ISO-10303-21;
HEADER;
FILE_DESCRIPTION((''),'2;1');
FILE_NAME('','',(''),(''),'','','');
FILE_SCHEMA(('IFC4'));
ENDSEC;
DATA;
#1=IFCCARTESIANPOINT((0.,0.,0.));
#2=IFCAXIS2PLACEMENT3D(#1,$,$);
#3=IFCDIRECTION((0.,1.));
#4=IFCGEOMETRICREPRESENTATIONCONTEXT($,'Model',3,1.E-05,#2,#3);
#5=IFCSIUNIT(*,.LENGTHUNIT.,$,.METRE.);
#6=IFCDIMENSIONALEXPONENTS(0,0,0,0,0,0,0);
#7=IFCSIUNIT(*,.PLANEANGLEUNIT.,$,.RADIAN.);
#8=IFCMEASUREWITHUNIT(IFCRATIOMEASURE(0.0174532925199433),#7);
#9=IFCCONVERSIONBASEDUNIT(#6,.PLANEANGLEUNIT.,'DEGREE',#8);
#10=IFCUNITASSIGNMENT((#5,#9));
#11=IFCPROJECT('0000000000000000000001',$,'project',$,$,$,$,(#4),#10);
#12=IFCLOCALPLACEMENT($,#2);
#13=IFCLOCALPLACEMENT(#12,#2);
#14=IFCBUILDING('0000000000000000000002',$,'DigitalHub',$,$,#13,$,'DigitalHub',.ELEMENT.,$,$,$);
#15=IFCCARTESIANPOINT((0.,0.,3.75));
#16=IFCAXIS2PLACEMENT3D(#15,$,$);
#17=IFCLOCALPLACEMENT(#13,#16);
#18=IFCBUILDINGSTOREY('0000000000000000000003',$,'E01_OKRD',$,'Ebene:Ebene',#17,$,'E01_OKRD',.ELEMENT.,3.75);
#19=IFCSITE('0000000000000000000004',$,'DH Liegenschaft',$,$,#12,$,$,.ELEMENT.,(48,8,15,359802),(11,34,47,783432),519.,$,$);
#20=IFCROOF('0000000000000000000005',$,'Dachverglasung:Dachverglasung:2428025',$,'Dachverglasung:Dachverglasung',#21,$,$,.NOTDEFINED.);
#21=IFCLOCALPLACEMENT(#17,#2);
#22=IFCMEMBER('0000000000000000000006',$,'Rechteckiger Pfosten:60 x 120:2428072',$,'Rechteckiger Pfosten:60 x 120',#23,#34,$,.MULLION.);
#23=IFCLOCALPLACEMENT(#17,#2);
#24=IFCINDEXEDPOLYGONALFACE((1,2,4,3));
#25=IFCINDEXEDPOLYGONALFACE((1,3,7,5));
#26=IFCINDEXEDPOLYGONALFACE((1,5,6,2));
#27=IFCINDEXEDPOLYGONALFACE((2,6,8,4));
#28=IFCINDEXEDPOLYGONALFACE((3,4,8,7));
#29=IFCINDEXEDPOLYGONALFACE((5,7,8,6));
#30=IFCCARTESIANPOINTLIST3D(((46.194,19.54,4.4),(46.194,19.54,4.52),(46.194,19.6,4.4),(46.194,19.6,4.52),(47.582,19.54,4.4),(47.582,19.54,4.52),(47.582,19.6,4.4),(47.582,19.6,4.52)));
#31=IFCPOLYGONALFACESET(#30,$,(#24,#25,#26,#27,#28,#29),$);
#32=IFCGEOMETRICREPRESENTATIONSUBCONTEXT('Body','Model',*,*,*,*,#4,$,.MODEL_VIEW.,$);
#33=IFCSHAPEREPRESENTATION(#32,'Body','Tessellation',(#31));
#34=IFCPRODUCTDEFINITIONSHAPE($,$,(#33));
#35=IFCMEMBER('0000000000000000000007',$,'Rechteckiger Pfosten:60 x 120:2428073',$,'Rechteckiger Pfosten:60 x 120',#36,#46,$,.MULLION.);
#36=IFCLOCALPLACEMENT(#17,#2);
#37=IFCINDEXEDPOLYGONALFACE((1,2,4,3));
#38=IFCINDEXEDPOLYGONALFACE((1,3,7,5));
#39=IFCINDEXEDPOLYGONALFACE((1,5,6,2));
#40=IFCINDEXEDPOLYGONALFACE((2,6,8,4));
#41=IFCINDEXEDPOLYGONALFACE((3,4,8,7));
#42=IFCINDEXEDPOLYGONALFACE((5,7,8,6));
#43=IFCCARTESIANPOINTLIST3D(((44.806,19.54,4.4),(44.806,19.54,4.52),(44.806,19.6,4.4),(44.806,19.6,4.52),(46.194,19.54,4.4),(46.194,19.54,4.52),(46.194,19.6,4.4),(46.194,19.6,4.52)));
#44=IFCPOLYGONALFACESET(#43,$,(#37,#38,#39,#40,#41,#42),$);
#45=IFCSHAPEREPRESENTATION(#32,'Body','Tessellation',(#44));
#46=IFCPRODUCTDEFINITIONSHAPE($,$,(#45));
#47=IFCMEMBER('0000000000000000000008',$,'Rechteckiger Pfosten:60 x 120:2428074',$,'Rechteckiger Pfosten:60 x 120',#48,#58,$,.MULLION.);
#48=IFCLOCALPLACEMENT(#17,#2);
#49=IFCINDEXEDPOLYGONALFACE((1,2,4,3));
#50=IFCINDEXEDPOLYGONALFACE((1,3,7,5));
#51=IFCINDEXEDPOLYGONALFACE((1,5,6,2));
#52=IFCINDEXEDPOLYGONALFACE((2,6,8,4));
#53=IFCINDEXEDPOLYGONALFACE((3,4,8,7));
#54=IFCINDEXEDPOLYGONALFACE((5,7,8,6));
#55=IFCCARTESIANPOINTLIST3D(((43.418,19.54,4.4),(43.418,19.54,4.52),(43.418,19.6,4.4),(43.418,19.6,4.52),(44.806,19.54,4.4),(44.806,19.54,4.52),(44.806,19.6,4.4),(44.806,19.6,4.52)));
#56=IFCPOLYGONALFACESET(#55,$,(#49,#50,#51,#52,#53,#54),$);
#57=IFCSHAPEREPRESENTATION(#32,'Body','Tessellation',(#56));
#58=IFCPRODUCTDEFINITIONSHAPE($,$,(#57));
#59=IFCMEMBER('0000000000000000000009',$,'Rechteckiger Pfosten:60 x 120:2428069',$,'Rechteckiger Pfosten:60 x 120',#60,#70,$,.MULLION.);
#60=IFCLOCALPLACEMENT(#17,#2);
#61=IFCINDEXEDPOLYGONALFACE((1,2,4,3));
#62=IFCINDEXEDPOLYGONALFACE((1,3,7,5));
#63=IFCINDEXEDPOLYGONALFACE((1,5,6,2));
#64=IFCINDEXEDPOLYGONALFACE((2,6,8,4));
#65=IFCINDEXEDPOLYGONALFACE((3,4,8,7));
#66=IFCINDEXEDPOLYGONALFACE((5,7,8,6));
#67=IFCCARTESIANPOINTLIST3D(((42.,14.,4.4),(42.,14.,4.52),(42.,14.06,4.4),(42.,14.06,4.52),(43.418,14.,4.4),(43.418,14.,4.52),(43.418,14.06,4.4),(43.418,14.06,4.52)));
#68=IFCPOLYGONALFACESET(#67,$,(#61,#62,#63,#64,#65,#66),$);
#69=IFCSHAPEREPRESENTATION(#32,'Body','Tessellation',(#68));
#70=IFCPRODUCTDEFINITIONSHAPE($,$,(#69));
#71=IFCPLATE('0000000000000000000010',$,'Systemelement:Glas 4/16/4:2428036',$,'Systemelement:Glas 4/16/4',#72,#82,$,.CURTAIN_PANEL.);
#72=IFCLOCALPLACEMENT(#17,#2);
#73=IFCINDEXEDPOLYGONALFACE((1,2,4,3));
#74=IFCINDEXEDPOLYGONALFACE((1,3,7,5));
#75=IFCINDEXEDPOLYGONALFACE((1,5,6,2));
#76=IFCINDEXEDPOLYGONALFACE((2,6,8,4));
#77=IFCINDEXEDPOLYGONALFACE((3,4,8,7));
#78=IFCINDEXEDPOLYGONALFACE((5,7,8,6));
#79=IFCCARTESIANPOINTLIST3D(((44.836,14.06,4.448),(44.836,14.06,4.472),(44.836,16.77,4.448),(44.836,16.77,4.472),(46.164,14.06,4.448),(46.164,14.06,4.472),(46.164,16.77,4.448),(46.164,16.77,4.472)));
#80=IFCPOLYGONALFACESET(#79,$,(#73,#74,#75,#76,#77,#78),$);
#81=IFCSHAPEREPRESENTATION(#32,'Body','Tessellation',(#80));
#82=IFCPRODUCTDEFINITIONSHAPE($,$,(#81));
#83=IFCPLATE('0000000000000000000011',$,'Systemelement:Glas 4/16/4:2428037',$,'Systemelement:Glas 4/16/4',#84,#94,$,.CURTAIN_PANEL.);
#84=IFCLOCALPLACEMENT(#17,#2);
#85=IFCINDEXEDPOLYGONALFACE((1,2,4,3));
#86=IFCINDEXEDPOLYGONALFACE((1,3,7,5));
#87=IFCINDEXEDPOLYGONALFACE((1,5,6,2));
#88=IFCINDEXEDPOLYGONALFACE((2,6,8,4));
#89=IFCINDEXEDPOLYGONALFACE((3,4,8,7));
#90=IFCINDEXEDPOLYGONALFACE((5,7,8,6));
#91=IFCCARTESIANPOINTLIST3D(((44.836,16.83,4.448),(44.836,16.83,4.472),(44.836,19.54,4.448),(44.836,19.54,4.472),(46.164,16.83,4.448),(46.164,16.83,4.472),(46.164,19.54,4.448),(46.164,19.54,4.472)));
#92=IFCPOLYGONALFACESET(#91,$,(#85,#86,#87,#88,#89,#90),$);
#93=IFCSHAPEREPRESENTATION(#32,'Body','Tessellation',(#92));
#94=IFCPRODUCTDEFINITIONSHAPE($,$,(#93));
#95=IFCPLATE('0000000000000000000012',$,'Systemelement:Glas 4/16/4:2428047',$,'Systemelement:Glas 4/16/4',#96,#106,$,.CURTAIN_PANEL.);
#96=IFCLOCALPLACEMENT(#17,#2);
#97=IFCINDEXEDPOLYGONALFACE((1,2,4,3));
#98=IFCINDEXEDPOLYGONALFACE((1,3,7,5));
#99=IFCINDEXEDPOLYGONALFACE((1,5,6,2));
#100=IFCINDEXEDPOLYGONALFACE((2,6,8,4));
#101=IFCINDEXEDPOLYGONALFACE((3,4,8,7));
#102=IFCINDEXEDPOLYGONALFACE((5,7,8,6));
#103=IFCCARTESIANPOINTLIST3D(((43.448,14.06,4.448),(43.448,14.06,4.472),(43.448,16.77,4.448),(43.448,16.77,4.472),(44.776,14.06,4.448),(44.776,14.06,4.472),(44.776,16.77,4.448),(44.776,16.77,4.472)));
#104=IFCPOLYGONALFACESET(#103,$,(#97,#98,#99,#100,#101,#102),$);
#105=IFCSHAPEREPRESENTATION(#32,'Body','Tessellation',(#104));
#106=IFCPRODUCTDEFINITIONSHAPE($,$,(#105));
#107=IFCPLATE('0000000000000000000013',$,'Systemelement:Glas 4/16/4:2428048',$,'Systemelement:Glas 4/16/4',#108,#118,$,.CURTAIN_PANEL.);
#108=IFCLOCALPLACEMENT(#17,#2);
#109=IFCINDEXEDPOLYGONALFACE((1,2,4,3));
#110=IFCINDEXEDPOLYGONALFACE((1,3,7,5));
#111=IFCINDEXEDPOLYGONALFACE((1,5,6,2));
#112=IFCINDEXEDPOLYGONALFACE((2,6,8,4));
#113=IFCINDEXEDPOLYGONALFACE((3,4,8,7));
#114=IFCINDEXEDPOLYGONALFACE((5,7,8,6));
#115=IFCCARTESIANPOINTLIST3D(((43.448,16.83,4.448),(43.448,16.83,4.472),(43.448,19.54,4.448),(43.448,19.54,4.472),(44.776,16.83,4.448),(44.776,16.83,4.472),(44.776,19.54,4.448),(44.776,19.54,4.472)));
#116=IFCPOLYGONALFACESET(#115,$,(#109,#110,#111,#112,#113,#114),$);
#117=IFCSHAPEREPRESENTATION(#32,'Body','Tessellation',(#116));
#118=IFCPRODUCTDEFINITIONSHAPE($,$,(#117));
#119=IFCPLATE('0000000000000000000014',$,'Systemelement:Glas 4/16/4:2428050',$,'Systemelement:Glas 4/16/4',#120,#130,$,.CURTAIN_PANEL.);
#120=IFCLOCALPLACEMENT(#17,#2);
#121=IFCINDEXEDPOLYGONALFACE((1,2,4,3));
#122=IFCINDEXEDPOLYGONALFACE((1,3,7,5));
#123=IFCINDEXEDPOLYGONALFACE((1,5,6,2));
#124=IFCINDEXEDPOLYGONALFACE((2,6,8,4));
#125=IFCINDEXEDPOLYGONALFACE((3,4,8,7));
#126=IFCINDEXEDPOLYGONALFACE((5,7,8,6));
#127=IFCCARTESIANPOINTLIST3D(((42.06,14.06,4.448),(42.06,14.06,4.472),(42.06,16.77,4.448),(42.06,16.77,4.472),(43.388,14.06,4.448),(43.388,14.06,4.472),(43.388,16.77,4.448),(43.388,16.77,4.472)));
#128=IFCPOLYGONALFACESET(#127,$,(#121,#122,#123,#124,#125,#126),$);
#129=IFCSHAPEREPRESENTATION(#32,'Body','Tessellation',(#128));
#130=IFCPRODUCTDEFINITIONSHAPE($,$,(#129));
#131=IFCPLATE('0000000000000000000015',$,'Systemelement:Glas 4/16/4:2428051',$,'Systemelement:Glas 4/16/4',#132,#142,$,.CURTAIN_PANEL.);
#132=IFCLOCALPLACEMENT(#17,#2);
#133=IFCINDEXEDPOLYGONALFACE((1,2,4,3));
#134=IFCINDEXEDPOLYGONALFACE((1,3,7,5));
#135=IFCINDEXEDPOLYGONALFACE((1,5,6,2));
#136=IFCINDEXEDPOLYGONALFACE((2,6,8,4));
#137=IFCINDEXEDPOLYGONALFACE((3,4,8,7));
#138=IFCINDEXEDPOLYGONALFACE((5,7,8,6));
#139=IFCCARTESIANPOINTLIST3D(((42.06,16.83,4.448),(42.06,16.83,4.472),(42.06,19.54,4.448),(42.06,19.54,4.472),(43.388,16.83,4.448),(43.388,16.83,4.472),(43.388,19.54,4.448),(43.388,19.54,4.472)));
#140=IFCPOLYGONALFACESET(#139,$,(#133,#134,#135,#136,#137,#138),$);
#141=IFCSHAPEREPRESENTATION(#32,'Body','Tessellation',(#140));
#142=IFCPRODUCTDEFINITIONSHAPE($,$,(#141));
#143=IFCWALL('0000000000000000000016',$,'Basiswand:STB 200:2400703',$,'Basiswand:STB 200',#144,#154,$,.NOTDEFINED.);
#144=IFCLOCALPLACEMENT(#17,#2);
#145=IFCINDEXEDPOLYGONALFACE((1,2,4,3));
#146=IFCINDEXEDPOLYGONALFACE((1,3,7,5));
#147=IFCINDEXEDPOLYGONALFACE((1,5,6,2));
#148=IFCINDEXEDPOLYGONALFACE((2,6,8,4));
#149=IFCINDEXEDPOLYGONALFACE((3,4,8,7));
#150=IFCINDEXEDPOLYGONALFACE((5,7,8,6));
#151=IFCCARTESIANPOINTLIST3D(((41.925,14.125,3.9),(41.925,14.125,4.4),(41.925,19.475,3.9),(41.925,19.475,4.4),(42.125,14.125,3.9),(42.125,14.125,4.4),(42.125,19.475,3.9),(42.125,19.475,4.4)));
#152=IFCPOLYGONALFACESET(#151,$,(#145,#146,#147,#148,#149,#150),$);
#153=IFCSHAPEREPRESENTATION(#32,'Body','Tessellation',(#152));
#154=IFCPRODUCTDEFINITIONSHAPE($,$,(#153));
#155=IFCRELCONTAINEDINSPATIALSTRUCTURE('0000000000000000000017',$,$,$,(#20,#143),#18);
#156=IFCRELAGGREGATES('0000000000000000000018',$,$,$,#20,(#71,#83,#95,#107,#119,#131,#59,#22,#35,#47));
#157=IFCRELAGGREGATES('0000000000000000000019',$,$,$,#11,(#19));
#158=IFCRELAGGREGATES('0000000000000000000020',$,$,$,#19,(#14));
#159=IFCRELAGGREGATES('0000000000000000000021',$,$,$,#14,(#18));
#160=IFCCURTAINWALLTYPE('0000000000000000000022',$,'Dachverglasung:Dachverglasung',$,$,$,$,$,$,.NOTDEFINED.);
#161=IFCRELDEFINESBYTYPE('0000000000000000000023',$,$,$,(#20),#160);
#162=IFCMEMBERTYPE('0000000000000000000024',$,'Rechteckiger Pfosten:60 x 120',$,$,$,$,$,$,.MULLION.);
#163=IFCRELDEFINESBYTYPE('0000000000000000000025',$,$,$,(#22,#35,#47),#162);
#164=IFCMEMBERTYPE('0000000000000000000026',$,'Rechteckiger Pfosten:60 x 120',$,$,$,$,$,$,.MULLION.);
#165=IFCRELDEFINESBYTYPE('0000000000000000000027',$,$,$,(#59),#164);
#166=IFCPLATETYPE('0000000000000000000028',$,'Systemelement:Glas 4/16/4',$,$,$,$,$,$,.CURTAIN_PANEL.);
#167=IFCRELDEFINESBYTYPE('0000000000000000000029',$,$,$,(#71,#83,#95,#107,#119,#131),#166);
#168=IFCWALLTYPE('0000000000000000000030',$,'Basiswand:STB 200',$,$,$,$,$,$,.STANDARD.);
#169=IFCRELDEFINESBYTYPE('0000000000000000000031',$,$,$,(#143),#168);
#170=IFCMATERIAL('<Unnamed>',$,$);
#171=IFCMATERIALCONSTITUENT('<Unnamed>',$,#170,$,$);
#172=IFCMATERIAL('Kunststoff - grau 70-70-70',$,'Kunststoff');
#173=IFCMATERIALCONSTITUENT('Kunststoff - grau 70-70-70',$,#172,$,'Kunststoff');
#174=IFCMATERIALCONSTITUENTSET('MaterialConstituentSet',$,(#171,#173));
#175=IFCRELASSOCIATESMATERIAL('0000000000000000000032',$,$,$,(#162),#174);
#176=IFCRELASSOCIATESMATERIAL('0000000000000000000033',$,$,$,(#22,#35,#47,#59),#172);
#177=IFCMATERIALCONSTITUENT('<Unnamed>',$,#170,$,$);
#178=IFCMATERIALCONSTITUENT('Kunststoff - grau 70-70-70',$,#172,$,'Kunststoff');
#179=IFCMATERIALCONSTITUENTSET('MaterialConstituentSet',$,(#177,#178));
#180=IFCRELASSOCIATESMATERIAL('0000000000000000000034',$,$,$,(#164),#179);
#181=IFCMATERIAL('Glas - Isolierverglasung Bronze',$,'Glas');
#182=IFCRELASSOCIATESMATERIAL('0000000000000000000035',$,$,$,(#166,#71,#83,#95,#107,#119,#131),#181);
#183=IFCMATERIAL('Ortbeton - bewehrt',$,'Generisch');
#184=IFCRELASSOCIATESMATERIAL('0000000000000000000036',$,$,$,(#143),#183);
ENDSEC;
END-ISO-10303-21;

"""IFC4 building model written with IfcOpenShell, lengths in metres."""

from ifc_helpers import new_model, entity, si_unit, converted_unit, direction, frame, origin, place, context, subcontext, project, spatial, indexed_curve, outline, extrude, source, transform, mapped, material, constituent, constituent_set, type_object, type_shapes, element, aggregate, save


model = new_model("IFC4")

# Units and contexts
model_context = context("Model", 3, precision=1e-05, world=origin(), true_north=direction((0.0, 1.0)))
body_context = subcontext(model_context, "Body", "Model", "MODEL_VIEW")
ifc_project = project(units=[si_unit("LENGTHUNIT", "METRE"), converted_unit("PLANEANGLEUNIT", "DEGREE", entity("IfcRatioMeasure", 0.0174532925199433), si_unit("PLANEANGLEUNIT", "RADIAN"), dimensions=[0, 0, 0, 0, 0, 0, 0])], contexts=[model_context])

# Site, building, storey
site_placement = place(None, frame((0.0, 0.0, 0.0)))
site = spatial("IfcSite", under=ifc_project, at=site_placement, Name="DH Liegenschaft", CompositionType="ELEMENT", RefLatitude=(48, 8, 15, 359802), RefLongitude=(11, 34, 47, 783432), RefElevation=519.0)
building_placement = place(site_placement, origin())
building = spatial("IfcBuilding", under=site, at=building_placement, Name="DigitalHub", LongName="DigitalHub", CompositionType="ELEMENT")
storey_placement = place(building_placement, frame((0.0, 0.0, 3.75)))
storey = spatial("IfcBuildingStorey", under=building, at=storey_placement, Name="E01_OKRD", ObjectType="Ebene:Ebene", LongName="E01_OKRD", CompositionType="ELEMENT", Elevation=3.75)

# Roof, members, plates
curtain_wall_type = type_object("IfcCurtainWallType", Name="Dachverglasung:Dachverglasung", PredefinedType="NOTDEFINED")
roof_placement = place(storey_placement, frame((0.0, 0.0, -3.75)))
roof = element("IfcRoof", 1, at=roof_placement, inside=storey, type_object=curtain_wall_type, Name="Dachverglasung:Dachverglasung:2428025", ObjectType="Dachverglasung:Dachverglasung", PredefinedType="NOTDEFINED")
ifc_material_1 = material(Name="Kunststoff - grau 70-70-70", Category="Kunststoff")
ifc_material_2 = material(Name="<Unnamed>")
ifc_constituent_1 = constituent(ifc_material_2, Name="<Unnamed>")
ifc_constituent_2 = constituent(ifc_material_1, Name="Kunststoff - grau 70-70-70", Category="Kunststoff")
ifc_constituent_set_1 = constituent_set(constituents=[ifc_constituent_1, ifc_constituent_2], Name="MaterialConstituentSet")
member_type_1 = type_object("IfcMemberType", Name="Rechteckiger Pfosten:60 x 120", PredefinedType="MULLION", material=ifc_constituent_set_1)
shared_shape_1 = source(origin(), body_context, "Body", "SweptSolid", [
    extrude(outline(indexed_curve([(-0.06, -0.03), (0.06, -0.03), (0.06, 0.03), (-0.06, 0.03), (-0.06, -0.03)], self_intersect=False)), frame((-0.03, 0.0, -1.388), z_axis=(0.0, 0.0, 1.0), x_axis=(0.0, -1.0, 0.0)), (0.0, 0.0, 1.0), 1.388),
])
type_shapes(member_type_1, [shared_shape_1])
member_1_placement = place(storey_placement, frame((46.194, 19.6, 4.46), z_axis=(-1.0, 0.0, 0.0), x_axis=(0.0, 1.0, 0.0)))
member_1 = element("IfcMember", 2, at=member_1_placement, type_object=member_type_1, material=ifc_material_1, Name="Rechteckiger Pfosten:60 x 120:2428072", ObjectType="Rechteckiger Pfosten:60 x 120", PredefinedType="MULLION", context=body_context, shape_type="MappedRepresentation", body=[
    mapped(shared_shape_1, transform((0.0, 0.0, 0.0), scale=1.0)),
])
member_2_placement = place(storey_placement, frame((44.806, 19.6, 4.46), z_axis=(-1.0, 0.0, 0.0), x_axis=(0.0, 1.0, 0.0)))
member_2 = element("IfcMember", 3, at=member_2_placement, type_object=member_type_1, material=ifc_material_1, Name="Rechteckiger Pfosten:60 x 120:2428073", ObjectType="Rechteckiger Pfosten:60 x 120", PredefinedType="MULLION", context=body_context, shape_type="MappedRepresentation", body=[
    mapped(shared_shape_1, transform((0.0, 0.0, 0.0), scale=1.0)),
])
member_3_placement = place(storey_placement, frame((43.418, 19.6, 4.46), z_axis=(-1.0, 0.0, 0.0), x_axis=(0.0, 1.0, 0.0)))
member_3 = element("IfcMember", 4, at=member_3_placement, type_object=member_type_1, material=ifc_material_1, Name="Rechteckiger Pfosten:60 x 120:2428074", ObjectType="Rechteckiger Pfosten:60 x 120", PredefinedType="MULLION", context=body_context, shape_type="MappedRepresentation", body=[
    mapped(shared_shape_1, transform((0.0, 0.0, 0.0), scale=1.0)),
])
ifc_constituent_3 = constituent(ifc_material_2, Name="<Unnamed>")
ifc_constituent_4 = constituent(ifc_material_1, Name="Kunststoff - grau 70-70-70", Category="Kunststoff")
ifc_constituent_set_2 = constituent_set(constituents=[ifc_constituent_3, ifc_constituent_4], Name="MaterialConstituentSet")
member_type_2 = type_object("IfcMemberType", Name="Rechteckiger Pfosten:60 x 120", PredefinedType="MULLION", material=ifc_constituent_set_2)
shared_shape_2 = source(origin(), body_context, "Body", "SweptSolid", [
    extrude(outline(indexed_curve([(-0.06, -0.03), (0.06, -0.03), (0.06, 0.03), (-0.06, 0.03), (-0.06, -0.03)], self_intersect=False)), frame((-0.03, 0.0, -1.418), z_axis=(0.0, 0.0, 1.0), x_axis=(0.0, -1.0, 0.0)), (0.0, 0.0, 1.0), 1.418),
])
type_shapes(member_type_2, [shared_shape_2])
member_4_placement = place(storey_placement, frame((43.418, 14.0, 4.46), z_axis=(1.0, 0.0, 0.0), x_axis=(0.0, -1.0, 0.0)))
member_4 = element("IfcMember", 5, at=member_4_placement, type_object=member_type_2, material=ifc_material_1, Name="Rechteckiger Pfosten:60 x 120:2428069", ObjectType="Rechteckiger Pfosten:60 x 120", PredefinedType="MULLION", context=body_context, shape_type="MappedRepresentation", body=[
    mapped(shared_shape_2, transform((0.0, 0.0, 0.0), scale=1.0)),
])
ifc_material_3 = material(Name="Glas - Isolierverglasung Bronze", Category="Glas")
plate_type = type_object("IfcPlateType", Name="Systemelement:Glas 4/16/4", PredefinedType="CURTAIN_PANEL", material=ifc_material_3)
shared_shape_3 = source(origin(), body_context, "Body", "SweptSolid", [
    extrude(outline(indexed_curve([(-0.012, -1.355), (0.012, -1.355), (0.012, 1.355), (-0.012, 1.355), (-0.012, -1.355)], self_intersect=False)), frame((0.0, 0.0, 0.0), z_axis=(0.0, 0.0, 1.0), x_axis=(0.0, 1.0, 0.0)), (0.0, 0.0, 1.0), 1.328),
])
type_shapes(plate_type, [shared_shape_3])
plate_1_placement = place(roof_placement, frame((46.164, 15.415, 8.21), z_axis=(-1.0, 0.0, 0.0), x_axis=(0.0, 1.0, 0.0)))
plate_1 = element("IfcPlate", 6, at=plate_1_placement, type_object=plate_type, material=ifc_material_3, Name="Systemelement:Glas 4/16/4:2428036", ObjectType="Systemelement:Glas 4/16/4", PredefinedType="CURTAIN_PANEL", context=body_context, shape_type="MappedRepresentation", body=[
    mapped(shared_shape_3, transform((0.0, 0.0, 0.0), scale=1.0)),
])
plate_2_placement = place(roof_placement, frame((46.164, 18.185, 8.21), z_axis=(-1.0, 0.0, 0.0), x_axis=(0.0, 1.0, 0.0)))
plate_2 = element("IfcPlate", 7, at=plate_2_placement, type_object=plate_type, material=ifc_material_3, Name="Systemelement:Glas 4/16/4:2428037", ObjectType="Systemelement:Glas 4/16/4", PredefinedType="CURTAIN_PANEL", context=body_context, shape_type="MappedRepresentation", body=[
    mapped(shared_shape_3, transform((0.0, 0.0, 0.0), scale=1.0)),
])
plate_3_placement = place(roof_placement, frame((44.776, 15.415, 8.21), z_axis=(-1.0, 0.0, 0.0), x_axis=(0.0, 1.0, 0.0)))
plate_3 = element("IfcPlate", 8, at=plate_3_placement, type_object=plate_type, material=ifc_material_3, Name="Systemelement:Glas 4/16/4:2428047", ObjectType="Systemelement:Glas 4/16/4", PredefinedType="CURTAIN_PANEL", context=body_context, shape_type="MappedRepresentation", body=[
    mapped(shared_shape_3, transform((0.0, 0.0, 0.0), scale=1.0)),
])
plate_4_placement = place(roof_placement, frame((44.776, 18.185, 8.21), z_axis=(-1.0, 0.0, 0.0), x_axis=(0.0, 1.0, 0.0)))
plate_4 = element("IfcPlate", 9, at=plate_4_placement, type_object=plate_type, material=ifc_material_3, Name="Systemelement:Glas 4/16/4:2428048", ObjectType="Systemelement:Glas 4/16/4", PredefinedType="CURTAIN_PANEL", context=body_context, shape_type="MappedRepresentation", body=[
    mapped(shared_shape_3, transform((0.0, 0.0, 0.0), scale=1.0)),
])
plate_5_placement = place(roof_placement, frame((43.388, 15.415, 8.21), z_axis=(-1.0, 0.0, 0.0), x_axis=(0.0, 1.0, 0.0)))
plate_5 = element("IfcPlate", 10, at=plate_5_placement, type_object=plate_type, material=ifc_material_3, Name="Systemelement:Glas 4/16/4:2428050", ObjectType="Systemelement:Glas 4/16/4", PredefinedType="CURTAIN_PANEL", context=body_context, shape_type="MappedRepresentation", body=[
    mapped(shared_shape_3, transform((0.0, 0.0, 0.0), scale=1.0)),
])
plate_6_placement = place(roof_placement, frame((43.388, 18.185, 8.21), z_axis=(-1.0, 0.0, 0.0), x_axis=(0.0, 1.0, 0.0)))
plate_6 = element("IfcPlate", 11, at=plate_6_placement, type_object=plate_type, material=ifc_material_3, Name="Systemelement:Glas 4/16/4:2428051", ObjectType="Systemelement:Glas 4/16/4", PredefinedType="CURTAIN_PANEL", context=body_context, shape_type="MappedRepresentation", body=[
    mapped(shared_shape_3, transform((0.0, 0.0, 0.0), scale=1.0)),
])
aggregate(roof, [plate_1, plate_2, plate_3, plate_4, plate_5, plate_6, member_4, member_1, member_2, member_3])

# Wall
ifc_material_4 = material(Name="Ortbeton - bewehrt", Category="Generisch")
wall_type_1 = type_object("IfcWallType", Name="Basiswand:STB 200", PredefinedType="STANDARD")
wall_1_placement = place(storey_placement, frame((42.025, 14.125, 3.9), z_axis=(0.0, 0.0, 1.0), x_axis=(0.0, 1.0, 0.0)))
element("IfcWall", 12, at=wall_1_placement, inside=storey, type_object=wall_type_1, material=ifc_material_4, Name="Basiswand:STB 200:2400703", ObjectType="Basiswand:STB 200", PredefinedType="NOTDEFINED", context=body_context, shape_type="SweptSolid", body=[
    extrude(outline(indexed_curve([(5.35, 0.1), (0.0, 0.1), (0.0, -0.1), (5.35, -0.1), (5.35, 0.1)], self_intersect=False)), origin(), (0.0, 0.0, 1.0), 0.5),
])

save(model, "model.ifc")
